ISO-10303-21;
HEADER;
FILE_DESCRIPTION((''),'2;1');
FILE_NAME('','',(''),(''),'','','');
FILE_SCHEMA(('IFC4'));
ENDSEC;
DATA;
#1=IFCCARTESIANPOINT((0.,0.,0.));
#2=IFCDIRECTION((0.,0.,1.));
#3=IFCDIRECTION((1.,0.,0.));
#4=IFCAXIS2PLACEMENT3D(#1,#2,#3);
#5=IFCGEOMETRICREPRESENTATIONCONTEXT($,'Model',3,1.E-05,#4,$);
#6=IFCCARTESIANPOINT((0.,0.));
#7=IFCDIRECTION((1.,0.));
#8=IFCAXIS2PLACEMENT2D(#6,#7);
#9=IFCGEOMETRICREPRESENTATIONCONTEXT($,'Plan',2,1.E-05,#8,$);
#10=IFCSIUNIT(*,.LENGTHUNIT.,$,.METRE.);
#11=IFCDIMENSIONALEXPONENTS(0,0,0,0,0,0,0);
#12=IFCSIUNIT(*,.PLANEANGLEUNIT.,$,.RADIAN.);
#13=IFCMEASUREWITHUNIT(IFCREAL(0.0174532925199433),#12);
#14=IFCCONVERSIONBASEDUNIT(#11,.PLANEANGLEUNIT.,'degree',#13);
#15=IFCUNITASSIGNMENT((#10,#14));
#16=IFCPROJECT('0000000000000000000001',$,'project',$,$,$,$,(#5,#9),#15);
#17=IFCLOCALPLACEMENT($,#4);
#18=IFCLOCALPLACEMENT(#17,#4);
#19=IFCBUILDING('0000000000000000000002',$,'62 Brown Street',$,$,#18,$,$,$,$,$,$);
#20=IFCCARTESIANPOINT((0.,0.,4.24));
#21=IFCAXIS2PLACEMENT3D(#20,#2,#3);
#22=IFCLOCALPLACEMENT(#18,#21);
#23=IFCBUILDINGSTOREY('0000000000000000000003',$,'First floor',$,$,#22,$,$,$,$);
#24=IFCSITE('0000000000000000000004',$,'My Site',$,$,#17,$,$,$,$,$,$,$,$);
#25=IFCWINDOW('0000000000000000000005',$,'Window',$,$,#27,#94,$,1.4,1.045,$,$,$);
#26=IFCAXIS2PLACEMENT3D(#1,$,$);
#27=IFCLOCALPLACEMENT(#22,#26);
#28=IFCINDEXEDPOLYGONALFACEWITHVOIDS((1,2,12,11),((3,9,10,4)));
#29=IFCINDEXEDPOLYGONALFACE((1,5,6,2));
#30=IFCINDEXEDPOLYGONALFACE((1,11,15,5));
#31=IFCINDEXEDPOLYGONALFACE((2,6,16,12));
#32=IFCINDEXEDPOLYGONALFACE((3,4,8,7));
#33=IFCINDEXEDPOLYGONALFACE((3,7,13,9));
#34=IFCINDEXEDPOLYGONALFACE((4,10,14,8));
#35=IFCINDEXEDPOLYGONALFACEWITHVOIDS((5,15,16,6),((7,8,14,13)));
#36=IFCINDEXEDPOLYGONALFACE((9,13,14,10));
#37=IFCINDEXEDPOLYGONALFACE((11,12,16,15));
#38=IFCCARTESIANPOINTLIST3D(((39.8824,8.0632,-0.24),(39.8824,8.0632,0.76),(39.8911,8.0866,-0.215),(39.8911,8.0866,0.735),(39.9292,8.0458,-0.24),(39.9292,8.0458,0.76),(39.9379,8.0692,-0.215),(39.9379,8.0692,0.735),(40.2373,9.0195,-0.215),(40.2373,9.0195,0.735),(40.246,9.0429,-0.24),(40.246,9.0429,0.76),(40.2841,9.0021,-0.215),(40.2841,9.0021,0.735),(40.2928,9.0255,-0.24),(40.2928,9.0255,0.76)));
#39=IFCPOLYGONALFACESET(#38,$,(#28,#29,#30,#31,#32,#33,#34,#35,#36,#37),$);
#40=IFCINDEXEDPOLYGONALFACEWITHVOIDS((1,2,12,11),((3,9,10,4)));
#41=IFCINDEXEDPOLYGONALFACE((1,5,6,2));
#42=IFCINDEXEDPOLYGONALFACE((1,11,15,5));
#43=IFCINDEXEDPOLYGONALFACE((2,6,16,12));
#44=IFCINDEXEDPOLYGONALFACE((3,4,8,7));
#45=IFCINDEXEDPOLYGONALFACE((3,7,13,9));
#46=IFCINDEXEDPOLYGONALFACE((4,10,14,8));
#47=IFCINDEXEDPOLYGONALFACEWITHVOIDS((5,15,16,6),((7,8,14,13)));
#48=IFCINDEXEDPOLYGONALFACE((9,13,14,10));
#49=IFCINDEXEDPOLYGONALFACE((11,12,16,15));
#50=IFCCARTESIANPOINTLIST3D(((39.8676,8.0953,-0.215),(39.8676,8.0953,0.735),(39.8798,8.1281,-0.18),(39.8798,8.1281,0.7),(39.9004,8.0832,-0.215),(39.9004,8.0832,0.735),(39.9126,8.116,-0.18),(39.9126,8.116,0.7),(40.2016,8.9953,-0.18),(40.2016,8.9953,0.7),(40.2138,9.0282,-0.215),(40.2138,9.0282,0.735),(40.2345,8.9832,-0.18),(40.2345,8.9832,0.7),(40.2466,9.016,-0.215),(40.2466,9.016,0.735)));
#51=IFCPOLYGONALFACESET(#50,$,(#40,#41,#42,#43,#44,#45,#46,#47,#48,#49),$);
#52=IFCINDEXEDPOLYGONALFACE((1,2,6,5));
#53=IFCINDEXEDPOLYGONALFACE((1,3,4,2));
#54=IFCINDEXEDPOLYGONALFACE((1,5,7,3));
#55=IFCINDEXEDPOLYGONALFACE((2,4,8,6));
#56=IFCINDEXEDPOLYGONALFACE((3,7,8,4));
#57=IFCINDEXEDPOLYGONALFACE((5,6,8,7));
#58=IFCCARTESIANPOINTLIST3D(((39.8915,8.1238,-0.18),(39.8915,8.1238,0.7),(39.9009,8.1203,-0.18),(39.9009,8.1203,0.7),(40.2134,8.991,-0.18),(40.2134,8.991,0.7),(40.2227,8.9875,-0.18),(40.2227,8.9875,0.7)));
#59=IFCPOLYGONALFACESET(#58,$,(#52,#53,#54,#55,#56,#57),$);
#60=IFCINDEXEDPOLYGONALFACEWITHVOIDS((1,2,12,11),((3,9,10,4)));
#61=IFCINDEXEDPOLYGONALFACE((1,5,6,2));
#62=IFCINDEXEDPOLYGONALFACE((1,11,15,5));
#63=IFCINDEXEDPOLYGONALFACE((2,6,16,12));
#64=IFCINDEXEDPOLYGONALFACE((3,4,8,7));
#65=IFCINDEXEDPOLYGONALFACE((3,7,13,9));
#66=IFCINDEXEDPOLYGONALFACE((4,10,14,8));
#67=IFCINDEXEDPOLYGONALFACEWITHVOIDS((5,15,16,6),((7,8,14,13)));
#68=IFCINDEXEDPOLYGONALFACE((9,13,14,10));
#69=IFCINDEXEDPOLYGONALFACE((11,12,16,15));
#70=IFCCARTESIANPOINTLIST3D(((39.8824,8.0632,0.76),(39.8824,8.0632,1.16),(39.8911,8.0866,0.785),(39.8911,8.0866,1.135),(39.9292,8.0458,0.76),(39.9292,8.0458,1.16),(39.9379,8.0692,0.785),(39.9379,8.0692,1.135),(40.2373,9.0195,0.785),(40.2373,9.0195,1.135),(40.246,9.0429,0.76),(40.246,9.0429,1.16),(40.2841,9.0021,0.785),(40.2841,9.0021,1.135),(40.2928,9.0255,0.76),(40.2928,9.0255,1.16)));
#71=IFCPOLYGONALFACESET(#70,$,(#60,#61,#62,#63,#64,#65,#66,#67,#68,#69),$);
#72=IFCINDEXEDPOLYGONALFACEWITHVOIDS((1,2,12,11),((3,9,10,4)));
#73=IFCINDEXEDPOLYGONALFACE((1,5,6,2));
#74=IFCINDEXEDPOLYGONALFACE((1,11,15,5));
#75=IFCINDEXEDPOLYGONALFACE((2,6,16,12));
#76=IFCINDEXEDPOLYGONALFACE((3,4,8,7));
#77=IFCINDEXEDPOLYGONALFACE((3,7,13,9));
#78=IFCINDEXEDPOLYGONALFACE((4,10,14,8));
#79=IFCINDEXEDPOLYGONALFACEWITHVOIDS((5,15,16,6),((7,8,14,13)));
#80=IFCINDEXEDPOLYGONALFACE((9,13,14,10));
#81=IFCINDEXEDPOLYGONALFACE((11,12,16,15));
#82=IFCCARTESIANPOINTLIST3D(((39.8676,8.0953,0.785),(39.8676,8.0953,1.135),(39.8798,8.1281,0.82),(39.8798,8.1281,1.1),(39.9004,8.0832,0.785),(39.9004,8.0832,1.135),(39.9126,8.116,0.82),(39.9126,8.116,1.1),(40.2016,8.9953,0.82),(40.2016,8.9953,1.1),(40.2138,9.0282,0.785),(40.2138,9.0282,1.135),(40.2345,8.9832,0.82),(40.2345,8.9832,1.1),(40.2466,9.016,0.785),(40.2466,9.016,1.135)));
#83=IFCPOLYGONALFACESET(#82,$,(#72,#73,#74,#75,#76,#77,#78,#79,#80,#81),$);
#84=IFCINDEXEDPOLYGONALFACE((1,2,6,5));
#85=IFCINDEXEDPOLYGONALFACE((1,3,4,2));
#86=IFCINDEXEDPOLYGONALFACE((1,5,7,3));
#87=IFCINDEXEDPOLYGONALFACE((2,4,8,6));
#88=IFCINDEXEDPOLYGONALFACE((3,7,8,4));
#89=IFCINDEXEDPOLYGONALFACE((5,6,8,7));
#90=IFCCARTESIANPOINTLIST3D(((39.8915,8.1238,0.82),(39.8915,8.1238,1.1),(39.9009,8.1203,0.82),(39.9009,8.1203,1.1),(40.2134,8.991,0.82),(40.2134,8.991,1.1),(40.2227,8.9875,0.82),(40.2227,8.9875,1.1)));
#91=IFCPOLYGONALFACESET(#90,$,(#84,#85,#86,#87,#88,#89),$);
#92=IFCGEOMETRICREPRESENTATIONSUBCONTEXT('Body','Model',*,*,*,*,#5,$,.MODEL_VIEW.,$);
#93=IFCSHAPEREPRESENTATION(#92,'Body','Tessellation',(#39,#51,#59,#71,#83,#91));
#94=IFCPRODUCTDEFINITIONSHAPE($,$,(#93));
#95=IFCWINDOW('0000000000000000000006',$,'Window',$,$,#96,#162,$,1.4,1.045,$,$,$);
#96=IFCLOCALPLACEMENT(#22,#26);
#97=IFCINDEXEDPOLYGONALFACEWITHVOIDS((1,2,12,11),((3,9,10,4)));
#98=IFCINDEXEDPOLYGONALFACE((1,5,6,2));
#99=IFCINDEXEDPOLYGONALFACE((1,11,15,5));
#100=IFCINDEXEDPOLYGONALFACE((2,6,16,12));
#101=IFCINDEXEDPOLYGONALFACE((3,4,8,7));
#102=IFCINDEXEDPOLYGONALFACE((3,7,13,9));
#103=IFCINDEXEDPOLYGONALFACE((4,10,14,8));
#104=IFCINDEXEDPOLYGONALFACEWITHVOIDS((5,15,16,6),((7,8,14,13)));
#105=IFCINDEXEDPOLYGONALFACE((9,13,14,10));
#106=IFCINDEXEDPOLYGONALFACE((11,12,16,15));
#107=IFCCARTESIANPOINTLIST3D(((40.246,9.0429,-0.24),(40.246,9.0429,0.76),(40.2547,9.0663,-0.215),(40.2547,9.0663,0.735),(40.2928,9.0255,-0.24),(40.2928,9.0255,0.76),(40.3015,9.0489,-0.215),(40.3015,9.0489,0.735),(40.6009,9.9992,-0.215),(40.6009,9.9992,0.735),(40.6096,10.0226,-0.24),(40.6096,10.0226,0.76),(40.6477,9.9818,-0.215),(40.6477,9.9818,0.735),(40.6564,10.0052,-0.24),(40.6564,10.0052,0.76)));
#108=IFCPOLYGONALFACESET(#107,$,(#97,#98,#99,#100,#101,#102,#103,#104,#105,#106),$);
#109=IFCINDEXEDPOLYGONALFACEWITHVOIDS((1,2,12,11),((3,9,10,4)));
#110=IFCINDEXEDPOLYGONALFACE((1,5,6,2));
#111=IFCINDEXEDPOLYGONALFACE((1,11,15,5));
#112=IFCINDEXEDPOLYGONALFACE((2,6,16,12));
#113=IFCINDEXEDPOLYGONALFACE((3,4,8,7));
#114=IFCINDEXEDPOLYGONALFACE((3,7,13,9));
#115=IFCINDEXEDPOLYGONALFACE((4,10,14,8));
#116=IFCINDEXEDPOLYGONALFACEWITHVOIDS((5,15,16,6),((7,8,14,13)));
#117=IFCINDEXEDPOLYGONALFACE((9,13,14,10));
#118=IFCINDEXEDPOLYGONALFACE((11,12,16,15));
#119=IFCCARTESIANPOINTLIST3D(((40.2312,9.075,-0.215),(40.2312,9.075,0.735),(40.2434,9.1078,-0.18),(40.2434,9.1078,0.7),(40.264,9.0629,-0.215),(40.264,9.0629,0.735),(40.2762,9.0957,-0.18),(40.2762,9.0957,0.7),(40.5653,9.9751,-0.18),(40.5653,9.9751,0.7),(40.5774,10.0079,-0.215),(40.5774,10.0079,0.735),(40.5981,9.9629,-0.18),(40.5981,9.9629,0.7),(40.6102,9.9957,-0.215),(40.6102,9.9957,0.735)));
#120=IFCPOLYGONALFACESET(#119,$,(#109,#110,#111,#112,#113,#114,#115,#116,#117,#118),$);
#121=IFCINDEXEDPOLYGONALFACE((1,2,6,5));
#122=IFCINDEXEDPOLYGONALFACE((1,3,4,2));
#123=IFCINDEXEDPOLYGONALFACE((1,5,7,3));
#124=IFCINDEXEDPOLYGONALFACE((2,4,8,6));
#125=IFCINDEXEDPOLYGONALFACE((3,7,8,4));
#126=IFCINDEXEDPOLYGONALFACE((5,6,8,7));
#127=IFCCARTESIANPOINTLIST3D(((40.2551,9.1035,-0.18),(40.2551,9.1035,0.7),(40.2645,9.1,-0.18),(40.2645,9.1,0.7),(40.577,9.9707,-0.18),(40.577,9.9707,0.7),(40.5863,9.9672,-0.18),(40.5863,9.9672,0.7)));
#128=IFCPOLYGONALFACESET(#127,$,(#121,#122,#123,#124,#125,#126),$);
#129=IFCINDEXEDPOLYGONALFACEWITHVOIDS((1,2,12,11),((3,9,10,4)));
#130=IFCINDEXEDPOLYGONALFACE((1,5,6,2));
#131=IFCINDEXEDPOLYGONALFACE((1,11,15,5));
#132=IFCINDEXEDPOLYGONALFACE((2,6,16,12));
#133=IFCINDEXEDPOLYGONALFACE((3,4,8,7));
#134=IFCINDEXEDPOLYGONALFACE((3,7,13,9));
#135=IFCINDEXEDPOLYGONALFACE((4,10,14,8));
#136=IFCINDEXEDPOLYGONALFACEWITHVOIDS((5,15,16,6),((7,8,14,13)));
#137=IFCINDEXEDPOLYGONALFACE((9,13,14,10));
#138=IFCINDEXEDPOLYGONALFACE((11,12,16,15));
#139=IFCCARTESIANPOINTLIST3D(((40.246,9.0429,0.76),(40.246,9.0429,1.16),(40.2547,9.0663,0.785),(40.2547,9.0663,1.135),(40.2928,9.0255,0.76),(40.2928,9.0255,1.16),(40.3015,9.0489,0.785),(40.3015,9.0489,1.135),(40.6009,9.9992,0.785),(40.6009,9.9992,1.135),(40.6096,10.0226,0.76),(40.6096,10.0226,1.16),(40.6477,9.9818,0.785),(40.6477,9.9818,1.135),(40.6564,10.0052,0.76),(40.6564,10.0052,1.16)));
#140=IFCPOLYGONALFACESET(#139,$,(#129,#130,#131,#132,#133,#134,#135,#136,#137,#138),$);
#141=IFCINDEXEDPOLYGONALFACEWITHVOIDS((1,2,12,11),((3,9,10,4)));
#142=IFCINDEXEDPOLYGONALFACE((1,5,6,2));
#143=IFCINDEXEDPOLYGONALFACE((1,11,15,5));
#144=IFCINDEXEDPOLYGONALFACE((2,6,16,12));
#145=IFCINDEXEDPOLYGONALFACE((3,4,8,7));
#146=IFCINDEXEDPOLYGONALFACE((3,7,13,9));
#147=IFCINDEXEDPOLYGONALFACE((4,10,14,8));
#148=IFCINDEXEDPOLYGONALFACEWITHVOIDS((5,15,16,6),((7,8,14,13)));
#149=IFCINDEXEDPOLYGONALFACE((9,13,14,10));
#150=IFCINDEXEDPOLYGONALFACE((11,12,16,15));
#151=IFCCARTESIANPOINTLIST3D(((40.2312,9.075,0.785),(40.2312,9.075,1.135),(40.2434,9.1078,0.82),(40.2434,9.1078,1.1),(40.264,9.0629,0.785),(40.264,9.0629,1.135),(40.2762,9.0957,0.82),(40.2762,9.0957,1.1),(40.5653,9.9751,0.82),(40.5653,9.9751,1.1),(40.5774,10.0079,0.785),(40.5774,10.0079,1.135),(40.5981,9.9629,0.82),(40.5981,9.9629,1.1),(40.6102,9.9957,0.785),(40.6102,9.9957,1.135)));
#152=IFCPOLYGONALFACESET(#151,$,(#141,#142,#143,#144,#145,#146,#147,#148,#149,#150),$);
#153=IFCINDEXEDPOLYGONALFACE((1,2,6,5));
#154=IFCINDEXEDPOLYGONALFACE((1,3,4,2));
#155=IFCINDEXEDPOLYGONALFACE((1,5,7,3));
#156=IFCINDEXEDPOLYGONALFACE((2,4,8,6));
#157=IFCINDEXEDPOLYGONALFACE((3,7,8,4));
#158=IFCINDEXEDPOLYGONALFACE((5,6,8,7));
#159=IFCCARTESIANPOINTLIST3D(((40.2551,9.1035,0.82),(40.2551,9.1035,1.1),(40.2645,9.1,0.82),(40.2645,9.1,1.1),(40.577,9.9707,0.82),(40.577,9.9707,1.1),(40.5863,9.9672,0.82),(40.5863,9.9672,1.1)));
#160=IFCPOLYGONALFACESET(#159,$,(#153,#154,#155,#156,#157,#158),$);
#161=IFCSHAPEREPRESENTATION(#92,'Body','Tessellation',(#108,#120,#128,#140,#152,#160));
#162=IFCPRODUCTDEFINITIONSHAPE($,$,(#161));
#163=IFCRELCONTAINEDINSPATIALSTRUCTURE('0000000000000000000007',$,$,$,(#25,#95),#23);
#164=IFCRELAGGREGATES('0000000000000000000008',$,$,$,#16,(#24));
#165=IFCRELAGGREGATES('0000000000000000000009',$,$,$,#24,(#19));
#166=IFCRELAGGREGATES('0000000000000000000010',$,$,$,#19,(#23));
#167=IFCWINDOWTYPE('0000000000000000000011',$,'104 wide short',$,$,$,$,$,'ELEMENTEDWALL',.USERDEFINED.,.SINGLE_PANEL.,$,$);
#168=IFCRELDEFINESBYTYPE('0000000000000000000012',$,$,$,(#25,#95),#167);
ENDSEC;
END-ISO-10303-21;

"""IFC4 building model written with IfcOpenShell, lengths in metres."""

from ifc_helpers import new_model, entity, si_unit, converted_unit, frame, origin_with_axes, origin_2d_with_axis, place, context, subcontext, project, spatial, line, indexed_curve, outline, extrude, shape, source, transform, mapped, type_object, type_shapes, element, save


model = new_model("IFC4")

# Units and contexts
model_context = context("Model", 3, precision=1e-05, world=origin_with_axes())
plan_context = context("Plan", 2, precision=1e-05, world=origin_2d_with_axis())
body_context_1 = subcontext(model_context, "Body", "Model", "MODEL_VIEW")
body_context_2 = subcontext(plan_context, "Body", "Plan", "PLAN_VIEW")
ifc_project = project(units=[si_unit("LENGTHUNIT", "METRE"), converted_unit("PLANEANGLEUNIT", "degree", entity("IfcReal", 0.0174532925199433), si_unit("PLANEANGLEUNIT", "RADIAN"), dimensions=[0, 0, 0, 0, 0, 0, 0])], contexts=[model_context, plan_context])

# Site, building, storey
site_placement = place(None, origin_with_axes())
site = spatial("IfcSite", under=ifc_project, at=site_placement, Name="My Site")
building_placement = place(site_placement, origin_with_axes())
building = spatial("IfcBuilding", under=site, at=building_placement, Name="62 Brown Street")
storey_placement = place(building_placement, frame((0.0, 0.0, 4.24), z_axis=(0.0, 0.0, 1.0), x_axis=(1.0, 0.0, 0.0)))
storey = spatial("IfcBuildingStorey", under=building, at=storey_placement, Name="First floor")

# Shared definitions
window_type = type_object("IfcWindowType", Name="104 wide short", ElementType="ELEMENTEDWALL", PartitioningType="SINGLE_PANEL", PredefinedType="USERDEFINED")
shared_shape_1 = source(origin_with_axes(), body_context_1, "Body", "SweptSolid", [
    extrude(outline(indexed_curve([(0.0, 0.0), (1.045, 0.0), (1.045, 1.0), (0.0, 1.0)], segments=[line(1, 2, 3, 4, 1)]), holes=[indexed_curve([(0.025, 0.025), (1.02, 0.025), (1.02, 0.975), (0.025, 0.975)], segments=[line(1, 2, 3, 4, 1)])]), frame((0.0, 0.15, 0.0), z_axis=(0.0, -1.0, 0.0), x_axis=(1.0, 0.0, 0.0)), (0.0, 0.0, -1.0), 0.05),
    extrude(outline(indexed_curve([(0.0, 0.0), (0.995, 0.0), (0.995, 0.95), (0.0, 0.95)], segments=[line(1, 2, 3, 4, 1)]), holes=[indexed_curve([(0.035, 0.035), (0.96, 0.035), (0.96, 0.915), (0.035, 0.915)], segments=[line(1, 2, 3, 4, 1)])]), frame((0.025, 0.19, 0.025), z_axis=(0.0, -1.0, 0.0), x_axis=(1.0, 0.0, 0.0)), (0.0, 0.0, -1.0), 0.035),
    extrude(outline(indexed_curve([(0.035, 0.035), (0.96, 0.035), (0.96, 0.915), (0.035, 0.915)], segments=[line(1, 2, 3, 4, 1)])), frame((0.025, 0.2025, 0.025), z_axis=(0.0, -1.0, 0.0), x_axis=(1.0, 0.0, 0.0)), (0.0, 0.0, -1.0), 0.01),
    extrude(outline(indexed_curve([(0.0, 0.0), (1.045, 0.0), (1.045, 0.4), (0.0, 0.4)], segments=[line(1, 2, 3, 4, 1)]), holes=[indexed_curve([(0.025, 0.025), (1.02, 0.025), (1.02, 0.375), (0.025, 0.375)], segments=[line(1, 2, 3, 4, 1)])]), frame((0.0, 0.15, 1.0), z_axis=(0.0, -1.0, 0.0), x_axis=(1.0, 0.0, 0.0)), (0.0, 0.0, -1.0), 0.05),
    extrude(outline(indexed_curve([(0.0, 0.0), (0.995, 0.0), (0.995, 0.35), (0.0, 0.35)], segments=[line(1, 2, 3, 4, 1)]), holes=[indexed_curve([(0.035, 0.035), (0.96, 0.035), (0.96, 0.315), (0.035, 0.315)], segments=[line(1, 2, 3, 4, 1)])]), frame((0.025, 0.19, 1.025), z_axis=(0.0, -1.0, 0.0), x_axis=(1.0, 0.0, 0.0)), (0.0, 0.0, -1.0), 0.035),
    extrude(outline(indexed_curve([(0.035, 0.035), (0.96, 0.035), (0.96, 0.315), (0.035, 0.315)], segments=[line(1, 2, 3, 4, 1)])), frame((0.025, 0.2025, 1.025), z_axis=(0.0, -1.0, 0.0), x_axis=(1.0, 0.0, 0.0)), (0.0, 0.0, -1.0), 0.01),
])
shared_shape_2 = source(origin_with_axes(), body_context_2, "Body", "Curve2D", [
    entity("IfcIndexedPolyCurve", entity("IfcCartesianPointList2D", [[0.025, 0.15], [1.02, 0.15]])),
    entity("IfcIndexedPolyCurve", entity("IfcCartesianPointList2D", [[0.0, 0.2], [0.025, 0.2], [0.025, 0.15], [0.0, 0.15]]), [entity("IfcLineIndex", [1, 2, 3, 4, 1])]),
    entity("IfcIndexedPolyCurve", entity("IfcCartesianPointList2D", [[1.045, 0.2], [1.02, 0.2], [1.02, 0.15], [1.045, 0.15]]), [entity("IfcLineIndex", [1, 2, 3, 4, 1])]),
    entity("IfcIndexedPolyCurve", entity("IfcCartesianPointList2D", [[0.025, 0.19], [0.06, 0.19], [0.06, 0.225], [0.025, 0.225]]), [entity("IfcLineIndex", [1, 2, 3, 4, 1])]),
    entity("IfcIndexedPolyCurve", entity("IfcCartesianPointList2D", [[1.02, 0.19], [0.985, 0.19], [0.985, 0.225], [1.02, 0.225]]), [entity("IfcLineIndex", [1, 2, 3, 4, 1])]),
    entity("IfcIndexedPolyCurve", entity("IfcCartesianPointList2D", [[0.06, 0.19], [0.985, 0.19]])),
    entity("IfcIndexedPolyCurve", entity("IfcCartesianPointList2D", [[0.06, 0.225], [0.985, 0.225]])),
    entity("IfcIndexedPolyCurve", entity("IfcCartesianPointList2D", [[0.06, 0.2075], [0.985, 0.2075]])),
])
type_shapes(window_type, [shared_shape_1, shared_shape_2])

# Windows
for number, where, z_axis, x_axis, name in (
    (1, (40.0699, 7.9936, -0.24), (0.0, 0.0, 1.0), (0.347944, 0.937515, 0.0), "Window"),
    (2, (40.4335, 8.9733, -0.24), (0.0, 0.0, 1.0), (0.347944, 0.937515, 0.0), "Window"),
):
    element("IfcWindow", number, at=place(storey_placement, frame(where, z_axis=z_axis, x_axis=x_axis)), inside=storey, type_object=window_type, Name=name, OverallHeight=1.4, OverallWidth=1.045, shapes=[
        shape(body_context_1, "Body", "MappedRepresentation", [mapped(shared_shape_1, transform((0.0, 0.0, 0.0), x_axis=(1.0, 0.0, 0.0), y_axis=(0.0, 1.0, 0.0), z_axis=(0.0, 0.0, 1.0), scale=1.0))]),
        shape(body_context_2, "Body", "MappedRepresentation", [mapped(shared_shape_2, transform((0.0, 0.0, 0.0), x_axis=(1.0, 0.0, 0.0), y_axis=(0.0, 1.0, 0.0), z_axis=(0.0, 0.0, 1.0), scale=1.0))]),
    ])

save(model, "model.ifc")
